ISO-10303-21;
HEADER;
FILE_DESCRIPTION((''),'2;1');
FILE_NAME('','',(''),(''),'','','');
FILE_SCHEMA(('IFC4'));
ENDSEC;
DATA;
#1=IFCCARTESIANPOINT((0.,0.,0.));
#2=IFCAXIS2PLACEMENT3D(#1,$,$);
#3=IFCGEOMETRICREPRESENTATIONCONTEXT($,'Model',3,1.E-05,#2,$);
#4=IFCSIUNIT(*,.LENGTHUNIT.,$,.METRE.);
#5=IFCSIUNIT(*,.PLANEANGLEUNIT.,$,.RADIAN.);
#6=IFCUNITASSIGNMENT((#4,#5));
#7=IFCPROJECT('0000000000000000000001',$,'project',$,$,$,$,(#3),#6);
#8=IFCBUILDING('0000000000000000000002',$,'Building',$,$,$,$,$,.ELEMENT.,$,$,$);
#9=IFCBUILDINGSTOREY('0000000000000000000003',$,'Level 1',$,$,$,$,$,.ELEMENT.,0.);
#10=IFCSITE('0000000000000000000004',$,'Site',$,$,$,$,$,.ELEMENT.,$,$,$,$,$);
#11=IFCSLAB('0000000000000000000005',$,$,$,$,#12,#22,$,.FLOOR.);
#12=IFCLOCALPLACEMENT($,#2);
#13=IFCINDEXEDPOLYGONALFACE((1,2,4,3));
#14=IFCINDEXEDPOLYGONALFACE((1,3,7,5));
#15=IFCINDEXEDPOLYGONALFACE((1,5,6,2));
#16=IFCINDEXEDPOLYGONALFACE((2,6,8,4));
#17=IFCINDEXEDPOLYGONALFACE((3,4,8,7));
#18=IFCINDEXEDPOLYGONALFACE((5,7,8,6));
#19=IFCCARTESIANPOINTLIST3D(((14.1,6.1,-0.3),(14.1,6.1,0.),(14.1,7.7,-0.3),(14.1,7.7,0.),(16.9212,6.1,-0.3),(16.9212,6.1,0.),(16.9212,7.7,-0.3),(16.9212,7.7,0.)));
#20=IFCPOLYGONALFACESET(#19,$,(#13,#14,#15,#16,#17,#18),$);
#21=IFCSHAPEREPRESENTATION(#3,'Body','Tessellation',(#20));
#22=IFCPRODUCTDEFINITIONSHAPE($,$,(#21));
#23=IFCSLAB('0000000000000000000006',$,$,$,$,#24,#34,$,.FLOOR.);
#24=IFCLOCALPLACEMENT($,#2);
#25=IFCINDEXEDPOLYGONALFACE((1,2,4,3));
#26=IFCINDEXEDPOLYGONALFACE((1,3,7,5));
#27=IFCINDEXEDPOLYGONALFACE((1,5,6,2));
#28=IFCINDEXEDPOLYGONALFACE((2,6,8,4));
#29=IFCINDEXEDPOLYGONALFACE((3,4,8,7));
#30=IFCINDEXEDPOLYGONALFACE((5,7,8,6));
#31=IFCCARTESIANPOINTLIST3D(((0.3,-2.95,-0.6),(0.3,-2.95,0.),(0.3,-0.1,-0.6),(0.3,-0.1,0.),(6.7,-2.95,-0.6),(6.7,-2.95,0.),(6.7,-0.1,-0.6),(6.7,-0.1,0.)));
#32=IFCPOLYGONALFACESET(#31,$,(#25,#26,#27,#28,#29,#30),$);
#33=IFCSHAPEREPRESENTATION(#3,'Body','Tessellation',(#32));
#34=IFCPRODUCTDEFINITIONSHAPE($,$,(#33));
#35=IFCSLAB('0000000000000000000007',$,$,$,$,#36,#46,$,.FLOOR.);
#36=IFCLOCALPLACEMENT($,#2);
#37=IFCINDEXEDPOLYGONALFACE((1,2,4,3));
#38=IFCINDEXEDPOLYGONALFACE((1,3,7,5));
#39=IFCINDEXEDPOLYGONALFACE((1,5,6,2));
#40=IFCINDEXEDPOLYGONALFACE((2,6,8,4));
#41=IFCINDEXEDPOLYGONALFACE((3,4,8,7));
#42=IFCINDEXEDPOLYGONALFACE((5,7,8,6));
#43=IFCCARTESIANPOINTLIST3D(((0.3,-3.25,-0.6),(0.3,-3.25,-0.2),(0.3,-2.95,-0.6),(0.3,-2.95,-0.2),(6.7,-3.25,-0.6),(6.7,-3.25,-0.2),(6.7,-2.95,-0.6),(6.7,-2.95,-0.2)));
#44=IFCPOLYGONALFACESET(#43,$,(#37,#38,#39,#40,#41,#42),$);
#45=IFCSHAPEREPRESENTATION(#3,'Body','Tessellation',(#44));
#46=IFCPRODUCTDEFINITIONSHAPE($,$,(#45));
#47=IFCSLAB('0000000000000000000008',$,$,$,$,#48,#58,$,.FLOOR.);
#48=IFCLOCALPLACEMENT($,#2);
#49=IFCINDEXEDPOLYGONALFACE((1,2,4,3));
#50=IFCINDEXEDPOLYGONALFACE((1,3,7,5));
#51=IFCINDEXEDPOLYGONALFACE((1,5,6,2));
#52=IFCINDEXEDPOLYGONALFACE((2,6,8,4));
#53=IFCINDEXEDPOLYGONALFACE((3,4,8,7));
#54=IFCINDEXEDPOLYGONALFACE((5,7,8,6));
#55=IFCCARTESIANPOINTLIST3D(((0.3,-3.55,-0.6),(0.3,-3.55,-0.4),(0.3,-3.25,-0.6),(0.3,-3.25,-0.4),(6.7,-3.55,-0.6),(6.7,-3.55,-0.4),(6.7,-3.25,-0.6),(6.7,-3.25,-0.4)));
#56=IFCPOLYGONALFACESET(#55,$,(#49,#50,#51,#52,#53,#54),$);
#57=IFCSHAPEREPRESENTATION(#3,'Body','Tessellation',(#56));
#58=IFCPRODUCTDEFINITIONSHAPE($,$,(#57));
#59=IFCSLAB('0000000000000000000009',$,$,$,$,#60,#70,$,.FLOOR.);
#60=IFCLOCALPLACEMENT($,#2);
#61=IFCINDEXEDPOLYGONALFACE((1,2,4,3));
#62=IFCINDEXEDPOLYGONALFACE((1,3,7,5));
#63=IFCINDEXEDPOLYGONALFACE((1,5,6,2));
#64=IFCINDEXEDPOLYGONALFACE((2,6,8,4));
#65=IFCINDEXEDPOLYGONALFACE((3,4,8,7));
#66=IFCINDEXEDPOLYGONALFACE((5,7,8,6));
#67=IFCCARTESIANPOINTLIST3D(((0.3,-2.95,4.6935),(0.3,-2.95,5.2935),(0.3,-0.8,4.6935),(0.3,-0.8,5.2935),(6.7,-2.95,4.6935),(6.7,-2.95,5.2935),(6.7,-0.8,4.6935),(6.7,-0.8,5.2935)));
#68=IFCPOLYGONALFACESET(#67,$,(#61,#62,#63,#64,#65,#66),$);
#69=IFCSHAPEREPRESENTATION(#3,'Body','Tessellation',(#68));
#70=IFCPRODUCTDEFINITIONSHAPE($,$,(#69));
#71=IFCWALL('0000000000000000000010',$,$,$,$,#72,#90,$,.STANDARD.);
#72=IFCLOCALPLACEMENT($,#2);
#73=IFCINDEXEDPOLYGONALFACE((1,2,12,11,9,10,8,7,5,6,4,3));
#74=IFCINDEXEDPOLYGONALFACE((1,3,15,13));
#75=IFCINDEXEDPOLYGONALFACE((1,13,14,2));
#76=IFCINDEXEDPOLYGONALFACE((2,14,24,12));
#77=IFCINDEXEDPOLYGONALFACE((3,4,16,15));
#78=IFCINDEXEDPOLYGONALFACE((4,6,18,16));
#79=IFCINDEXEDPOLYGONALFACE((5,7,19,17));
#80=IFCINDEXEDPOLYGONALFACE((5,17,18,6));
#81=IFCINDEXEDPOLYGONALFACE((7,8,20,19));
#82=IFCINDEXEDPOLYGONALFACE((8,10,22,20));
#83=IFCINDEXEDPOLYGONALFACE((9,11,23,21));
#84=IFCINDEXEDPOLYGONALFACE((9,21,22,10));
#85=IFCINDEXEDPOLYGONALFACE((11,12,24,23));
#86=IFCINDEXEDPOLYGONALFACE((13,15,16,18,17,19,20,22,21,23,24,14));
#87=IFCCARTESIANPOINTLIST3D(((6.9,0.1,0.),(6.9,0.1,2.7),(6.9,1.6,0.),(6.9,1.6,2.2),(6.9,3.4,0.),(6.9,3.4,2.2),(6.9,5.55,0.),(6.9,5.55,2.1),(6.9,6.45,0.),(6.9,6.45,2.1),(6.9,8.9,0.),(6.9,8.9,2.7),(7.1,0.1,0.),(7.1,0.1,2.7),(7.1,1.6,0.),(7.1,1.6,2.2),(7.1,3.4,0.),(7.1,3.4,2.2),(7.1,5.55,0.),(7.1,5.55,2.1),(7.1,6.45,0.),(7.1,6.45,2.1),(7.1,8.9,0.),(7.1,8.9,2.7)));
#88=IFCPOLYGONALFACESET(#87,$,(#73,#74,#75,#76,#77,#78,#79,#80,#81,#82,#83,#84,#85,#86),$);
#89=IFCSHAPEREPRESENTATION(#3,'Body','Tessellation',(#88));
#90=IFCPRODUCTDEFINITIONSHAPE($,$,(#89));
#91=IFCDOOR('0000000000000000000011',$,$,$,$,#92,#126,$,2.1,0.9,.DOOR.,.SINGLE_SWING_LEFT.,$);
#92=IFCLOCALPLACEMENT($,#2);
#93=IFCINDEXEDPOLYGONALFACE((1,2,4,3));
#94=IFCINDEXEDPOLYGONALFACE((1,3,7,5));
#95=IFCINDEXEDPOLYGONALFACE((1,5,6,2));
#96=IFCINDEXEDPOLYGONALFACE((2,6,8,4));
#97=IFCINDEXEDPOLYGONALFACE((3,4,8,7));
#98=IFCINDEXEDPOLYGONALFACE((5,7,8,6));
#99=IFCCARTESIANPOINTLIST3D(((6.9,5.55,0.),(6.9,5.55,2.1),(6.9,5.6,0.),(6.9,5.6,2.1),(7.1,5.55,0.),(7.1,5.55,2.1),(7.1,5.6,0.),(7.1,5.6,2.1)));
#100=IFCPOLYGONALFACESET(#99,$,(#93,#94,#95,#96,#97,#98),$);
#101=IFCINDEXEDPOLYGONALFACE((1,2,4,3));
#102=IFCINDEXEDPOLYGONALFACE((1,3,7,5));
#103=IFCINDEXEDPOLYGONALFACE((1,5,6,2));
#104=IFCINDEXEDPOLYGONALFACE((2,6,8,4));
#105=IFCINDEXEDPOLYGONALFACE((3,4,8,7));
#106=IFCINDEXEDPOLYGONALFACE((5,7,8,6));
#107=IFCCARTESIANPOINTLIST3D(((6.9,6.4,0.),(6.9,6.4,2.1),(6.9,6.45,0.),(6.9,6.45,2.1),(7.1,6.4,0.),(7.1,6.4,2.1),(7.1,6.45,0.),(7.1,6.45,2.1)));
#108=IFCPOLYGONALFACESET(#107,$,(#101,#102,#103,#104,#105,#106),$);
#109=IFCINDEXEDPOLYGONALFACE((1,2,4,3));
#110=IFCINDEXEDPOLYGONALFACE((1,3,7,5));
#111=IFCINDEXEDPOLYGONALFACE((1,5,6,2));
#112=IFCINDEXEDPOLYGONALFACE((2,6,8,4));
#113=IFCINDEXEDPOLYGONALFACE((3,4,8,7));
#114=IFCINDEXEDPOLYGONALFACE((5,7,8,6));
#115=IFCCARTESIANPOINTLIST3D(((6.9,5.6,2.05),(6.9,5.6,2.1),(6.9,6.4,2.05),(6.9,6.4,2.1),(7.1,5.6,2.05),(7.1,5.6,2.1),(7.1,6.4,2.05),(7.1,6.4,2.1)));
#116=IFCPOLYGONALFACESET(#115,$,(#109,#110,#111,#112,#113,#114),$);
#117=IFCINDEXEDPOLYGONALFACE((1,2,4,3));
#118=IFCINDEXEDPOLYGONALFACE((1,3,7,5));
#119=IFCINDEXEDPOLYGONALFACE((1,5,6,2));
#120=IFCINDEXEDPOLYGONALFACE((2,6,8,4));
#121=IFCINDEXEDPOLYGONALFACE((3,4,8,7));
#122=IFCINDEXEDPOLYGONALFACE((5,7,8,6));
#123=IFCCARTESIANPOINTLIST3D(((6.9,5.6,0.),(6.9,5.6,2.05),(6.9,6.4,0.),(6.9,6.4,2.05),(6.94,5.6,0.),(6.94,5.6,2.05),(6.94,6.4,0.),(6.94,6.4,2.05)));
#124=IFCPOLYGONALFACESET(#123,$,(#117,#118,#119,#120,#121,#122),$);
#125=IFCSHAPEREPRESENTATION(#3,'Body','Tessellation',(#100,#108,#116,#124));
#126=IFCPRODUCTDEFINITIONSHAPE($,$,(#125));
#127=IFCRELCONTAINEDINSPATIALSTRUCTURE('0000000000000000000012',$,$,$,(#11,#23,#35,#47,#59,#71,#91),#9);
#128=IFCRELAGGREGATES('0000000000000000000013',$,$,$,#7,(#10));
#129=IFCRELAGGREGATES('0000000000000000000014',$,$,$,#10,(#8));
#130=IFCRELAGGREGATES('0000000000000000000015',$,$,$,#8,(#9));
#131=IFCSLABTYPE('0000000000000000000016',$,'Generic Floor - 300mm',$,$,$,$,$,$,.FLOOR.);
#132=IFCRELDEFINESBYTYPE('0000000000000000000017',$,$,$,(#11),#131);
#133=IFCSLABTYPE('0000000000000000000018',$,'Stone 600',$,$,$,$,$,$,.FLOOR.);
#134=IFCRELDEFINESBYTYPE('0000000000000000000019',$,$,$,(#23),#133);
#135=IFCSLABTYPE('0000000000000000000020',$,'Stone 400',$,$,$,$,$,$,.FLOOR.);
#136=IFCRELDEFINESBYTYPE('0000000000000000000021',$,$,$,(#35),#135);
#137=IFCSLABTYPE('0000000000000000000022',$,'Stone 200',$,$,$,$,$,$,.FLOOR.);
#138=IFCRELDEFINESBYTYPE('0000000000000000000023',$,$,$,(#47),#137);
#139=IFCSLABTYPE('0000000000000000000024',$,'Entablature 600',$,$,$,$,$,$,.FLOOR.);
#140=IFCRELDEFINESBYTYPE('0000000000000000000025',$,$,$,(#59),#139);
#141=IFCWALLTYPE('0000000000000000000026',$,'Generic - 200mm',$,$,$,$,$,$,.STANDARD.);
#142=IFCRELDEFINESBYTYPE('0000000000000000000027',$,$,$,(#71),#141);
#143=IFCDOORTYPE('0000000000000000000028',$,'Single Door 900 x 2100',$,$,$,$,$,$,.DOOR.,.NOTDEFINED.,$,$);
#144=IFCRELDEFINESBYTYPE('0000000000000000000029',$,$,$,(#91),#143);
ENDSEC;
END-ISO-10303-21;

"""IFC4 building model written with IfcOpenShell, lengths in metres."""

from ifc_helpers import new_model, si_unit, frame, frame_2d, origin, origin_with_axes, origin_2d, place, context, project, spatial, polyline, rectangle, outline, extrude, type_object, element, fill, save


model = new_model("IFC4")

# Units and contexts
model_context = context("Model", 3, precision=1e-05, world=origin())
ifc_project = project(units=[si_unit("LENGTHUNIT", "METRE"), si_unit("PLANEANGLEUNIT", "RADIAN")], contexts=[model_context])

# Site, building, storey
site = spatial("IfcSite", under=ifc_project, Name="Site", CompositionType="ELEMENT")
building = spatial("IfcBuilding", under=site, Name="Building", CompositionType="ELEMENT")
storey = spatial("IfcBuildingStorey", under=building, Name="Level 1", CompositionType="ELEMENT", Elevation=0.0)

# Slabs
slab_type_1 = type_object("IfcSlabType", Name="Generic Floor - 300mm", PredefinedType="FLOOR")
slab_1_placement = place(None, origin())
element("IfcSlab", 1, at=slab_1_placement, inside=storey, type_object=slab_type_1, PredefinedType="FLOOR", context=model_context, shape_type="SweptSolid", body=[
    extrude(outline(polyline([(14.1, 6.1), (16.9212, 6.1), (16.9212, 7.7), (14.1, 7.7), (14.1, 6.1)])), origin(), (0.0, 0.0, -1.0), 0.3),
])
slab_type_2 = type_object("IfcSlabType", Name="Stone 600", PredefinedType="FLOOR")
slab_2_placement = place(None, origin())
element("IfcSlab", 2, at=slab_2_placement, inside=storey, type_object=slab_type_2, PredefinedType="FLOOR", context=model_context, shape_type="SweptSolid", body=[
    extrude(outline(polyline([(0.3, -2.95), (6.7, -2.95), (6.7, -0.1), (0.3, -0.1), (0.3, -2.95)])), origin(), (0.0, 0.0, -1.0), 0.6),
])
slab_type_3 = type_object("IfcSlabType", Name="Stone 400", PredefinedType="FLOOR")
slab_3_placement = place(None, frame((0.0, 0.0, -0.2)))
element("IfcSlab", 3, at=slab_3_placement, inside=storey, type_object=slab_type_3, PredefinedType="FLOOR", context=model_context, shape_type="SweptSolid", body=[
    extrude(outline(polyline([(0.3, -3.25), (6.7, -3.25), (6.7, -2.95), (0.3, -2.95), (0.3, -3.25)])), origin(), (0.0, 0.0, -1.0), 0.4),
])
slab_type_4 = type_object("IfcSlabType", Name="Stone 200", PredefinedType="FLOOR")
slab_4_placement = place(None, frame((0.0, 0.0, -0.4)))
element("IfcSlab", 4, at=slab_4_placement, inside=storey, type_object=slab_type_4, PredefinedType="FLOOR", context=model_context, shape_type="SweptSolid", body=[
    extrude(outline(polyline([(0.3, -3.55), (6.7, -3.55), (6.7, -3.25), (0.3, -3.25), (0.3, -3.55)])), origin(), (0.0, 0.0, -1.0), 0.2),
])
slab_type_5 = type_object("IfcSlabType", Name="Entablature 600", PredefinedType="FLOOR")
slab_5_placement = place(None, frame((0.0, 0.0, 5.2935)))
element("IfcSlab", 5, at=slab_5_placement, inside=storey, type_object=slab_type_5, PredefinedType="FLOOR", context=model_context, shape_type="SweptSolid", body=[
    extrude(outline(polyline([(0.3, -2.95), (6.7, -2.95), (6.7, -0.8), (0.3, -0.8), (0.3, -2.95)])), origin(), (0.0, 0.0, -1.0), 0.6),
])

# Wall, openings, door
wall_type_1 = type_object("IfcWallType", Name="Generic - 200mm", PredefinedType="STANDARD")
wall_1_placement = place(None, frame((7.0, 0.0, 0.0), z_axis=(0.0, 0.0, 1.0), x_axis=(0.0, 1.0, 0.0)))
wall_1 = element("IfcWall", 6, at=wall_1_placement, inside=storey, type_object=wall_type_1, PredefinedType="STANDARD", context=model_context, shape_type="SweptSolid", body=[
    extrude(outline(polyline([(0.1, -0.1), (8.9, -0.1), (8.9, 0.1), (0.1, 0.1), (0.1, -0.1)])), origin(), (0.0, 0.0, 1.0), 2.7),
])
opening_1_placement = place(wall_1_placement, frame((2.5, 0.0, 0.0), z_axis=(0.0, 0.0, 1.0), x_axis=(1.0, 0.0, 0.0)))
element("IfcOpeningElement", 7, at=opening_1_placement, cuts=wall_1, PredefinedType="OPENING", context=model_context, shape_type="SweptSolid", body=[
    extrude(rectangle(XDim=1.8, YDim=0.202, at=origin_2d()), origin(), (0.0, 0.0, 1.0), 2.2),
])
opening_2_placement = place(wall_1_placement, frame((6.0, 0.0, 0.0), z_axis=(0.0, 0.0, 1.0), x_axis=(1.0, 0.0, 0.0)))
opening_2 = element("IfcOpeningElement", 8, at=opening_2_placement, cuts=wall_1, PredefinedType="OPENING", context=model_context, shape_type="SweptSolid", body=[
    extrude(rectangle(XDim=0.9, YDim=0.202, at=origin_2d()), origin(), (0.0, 0.0, 1.0), 2.1),
])
door_type_1 = type_object("IfcDoorType", Name="Single Door 900 x 2100", OperationType="NOTDEFINED", PredefinedType="DOOR")
door_1_placement = place(opening_2_placement, origin_with_axes())
door_1 = element("IfcDoor", 9, at=door_1_placement, inside=storey, type_object=door_type_1, OperationType="SINGLE_SWING_LEFT", OverallHeight=2.1, OverallWidth=0.9, PredefinedType="DOOR", context=model_context, shape_type="SweptSolid", body=[
    extrude(rectangle(XDim=0.05, YDim=0.2, at=frame_2d((-0.425, 0.0))), origin(), (0.0, 0.0, 1.0), 2.1),
    extrude(rectangle(XDim=0.05, YDim=0.2, at=frame_2d((0.425, 0.0))), origin(), (0.0, 0.0, 1.0), 2.1),
    extrude(rectangle(XDim=0.8, YDim=0.2, at=origin_2d()), frame((0.0, 0.0, 2.05)), (0.0, 0.0, 1.0), 0.05),
    extrude(rectangle(XDim=0.8, YDim=0.04, at=frame_2d((0.0, 0.08))), origin(), (0.0, 0.0, 1.0), 2.05),
])
fill(opening_2, door_1)

save(model, "model.ifc")
